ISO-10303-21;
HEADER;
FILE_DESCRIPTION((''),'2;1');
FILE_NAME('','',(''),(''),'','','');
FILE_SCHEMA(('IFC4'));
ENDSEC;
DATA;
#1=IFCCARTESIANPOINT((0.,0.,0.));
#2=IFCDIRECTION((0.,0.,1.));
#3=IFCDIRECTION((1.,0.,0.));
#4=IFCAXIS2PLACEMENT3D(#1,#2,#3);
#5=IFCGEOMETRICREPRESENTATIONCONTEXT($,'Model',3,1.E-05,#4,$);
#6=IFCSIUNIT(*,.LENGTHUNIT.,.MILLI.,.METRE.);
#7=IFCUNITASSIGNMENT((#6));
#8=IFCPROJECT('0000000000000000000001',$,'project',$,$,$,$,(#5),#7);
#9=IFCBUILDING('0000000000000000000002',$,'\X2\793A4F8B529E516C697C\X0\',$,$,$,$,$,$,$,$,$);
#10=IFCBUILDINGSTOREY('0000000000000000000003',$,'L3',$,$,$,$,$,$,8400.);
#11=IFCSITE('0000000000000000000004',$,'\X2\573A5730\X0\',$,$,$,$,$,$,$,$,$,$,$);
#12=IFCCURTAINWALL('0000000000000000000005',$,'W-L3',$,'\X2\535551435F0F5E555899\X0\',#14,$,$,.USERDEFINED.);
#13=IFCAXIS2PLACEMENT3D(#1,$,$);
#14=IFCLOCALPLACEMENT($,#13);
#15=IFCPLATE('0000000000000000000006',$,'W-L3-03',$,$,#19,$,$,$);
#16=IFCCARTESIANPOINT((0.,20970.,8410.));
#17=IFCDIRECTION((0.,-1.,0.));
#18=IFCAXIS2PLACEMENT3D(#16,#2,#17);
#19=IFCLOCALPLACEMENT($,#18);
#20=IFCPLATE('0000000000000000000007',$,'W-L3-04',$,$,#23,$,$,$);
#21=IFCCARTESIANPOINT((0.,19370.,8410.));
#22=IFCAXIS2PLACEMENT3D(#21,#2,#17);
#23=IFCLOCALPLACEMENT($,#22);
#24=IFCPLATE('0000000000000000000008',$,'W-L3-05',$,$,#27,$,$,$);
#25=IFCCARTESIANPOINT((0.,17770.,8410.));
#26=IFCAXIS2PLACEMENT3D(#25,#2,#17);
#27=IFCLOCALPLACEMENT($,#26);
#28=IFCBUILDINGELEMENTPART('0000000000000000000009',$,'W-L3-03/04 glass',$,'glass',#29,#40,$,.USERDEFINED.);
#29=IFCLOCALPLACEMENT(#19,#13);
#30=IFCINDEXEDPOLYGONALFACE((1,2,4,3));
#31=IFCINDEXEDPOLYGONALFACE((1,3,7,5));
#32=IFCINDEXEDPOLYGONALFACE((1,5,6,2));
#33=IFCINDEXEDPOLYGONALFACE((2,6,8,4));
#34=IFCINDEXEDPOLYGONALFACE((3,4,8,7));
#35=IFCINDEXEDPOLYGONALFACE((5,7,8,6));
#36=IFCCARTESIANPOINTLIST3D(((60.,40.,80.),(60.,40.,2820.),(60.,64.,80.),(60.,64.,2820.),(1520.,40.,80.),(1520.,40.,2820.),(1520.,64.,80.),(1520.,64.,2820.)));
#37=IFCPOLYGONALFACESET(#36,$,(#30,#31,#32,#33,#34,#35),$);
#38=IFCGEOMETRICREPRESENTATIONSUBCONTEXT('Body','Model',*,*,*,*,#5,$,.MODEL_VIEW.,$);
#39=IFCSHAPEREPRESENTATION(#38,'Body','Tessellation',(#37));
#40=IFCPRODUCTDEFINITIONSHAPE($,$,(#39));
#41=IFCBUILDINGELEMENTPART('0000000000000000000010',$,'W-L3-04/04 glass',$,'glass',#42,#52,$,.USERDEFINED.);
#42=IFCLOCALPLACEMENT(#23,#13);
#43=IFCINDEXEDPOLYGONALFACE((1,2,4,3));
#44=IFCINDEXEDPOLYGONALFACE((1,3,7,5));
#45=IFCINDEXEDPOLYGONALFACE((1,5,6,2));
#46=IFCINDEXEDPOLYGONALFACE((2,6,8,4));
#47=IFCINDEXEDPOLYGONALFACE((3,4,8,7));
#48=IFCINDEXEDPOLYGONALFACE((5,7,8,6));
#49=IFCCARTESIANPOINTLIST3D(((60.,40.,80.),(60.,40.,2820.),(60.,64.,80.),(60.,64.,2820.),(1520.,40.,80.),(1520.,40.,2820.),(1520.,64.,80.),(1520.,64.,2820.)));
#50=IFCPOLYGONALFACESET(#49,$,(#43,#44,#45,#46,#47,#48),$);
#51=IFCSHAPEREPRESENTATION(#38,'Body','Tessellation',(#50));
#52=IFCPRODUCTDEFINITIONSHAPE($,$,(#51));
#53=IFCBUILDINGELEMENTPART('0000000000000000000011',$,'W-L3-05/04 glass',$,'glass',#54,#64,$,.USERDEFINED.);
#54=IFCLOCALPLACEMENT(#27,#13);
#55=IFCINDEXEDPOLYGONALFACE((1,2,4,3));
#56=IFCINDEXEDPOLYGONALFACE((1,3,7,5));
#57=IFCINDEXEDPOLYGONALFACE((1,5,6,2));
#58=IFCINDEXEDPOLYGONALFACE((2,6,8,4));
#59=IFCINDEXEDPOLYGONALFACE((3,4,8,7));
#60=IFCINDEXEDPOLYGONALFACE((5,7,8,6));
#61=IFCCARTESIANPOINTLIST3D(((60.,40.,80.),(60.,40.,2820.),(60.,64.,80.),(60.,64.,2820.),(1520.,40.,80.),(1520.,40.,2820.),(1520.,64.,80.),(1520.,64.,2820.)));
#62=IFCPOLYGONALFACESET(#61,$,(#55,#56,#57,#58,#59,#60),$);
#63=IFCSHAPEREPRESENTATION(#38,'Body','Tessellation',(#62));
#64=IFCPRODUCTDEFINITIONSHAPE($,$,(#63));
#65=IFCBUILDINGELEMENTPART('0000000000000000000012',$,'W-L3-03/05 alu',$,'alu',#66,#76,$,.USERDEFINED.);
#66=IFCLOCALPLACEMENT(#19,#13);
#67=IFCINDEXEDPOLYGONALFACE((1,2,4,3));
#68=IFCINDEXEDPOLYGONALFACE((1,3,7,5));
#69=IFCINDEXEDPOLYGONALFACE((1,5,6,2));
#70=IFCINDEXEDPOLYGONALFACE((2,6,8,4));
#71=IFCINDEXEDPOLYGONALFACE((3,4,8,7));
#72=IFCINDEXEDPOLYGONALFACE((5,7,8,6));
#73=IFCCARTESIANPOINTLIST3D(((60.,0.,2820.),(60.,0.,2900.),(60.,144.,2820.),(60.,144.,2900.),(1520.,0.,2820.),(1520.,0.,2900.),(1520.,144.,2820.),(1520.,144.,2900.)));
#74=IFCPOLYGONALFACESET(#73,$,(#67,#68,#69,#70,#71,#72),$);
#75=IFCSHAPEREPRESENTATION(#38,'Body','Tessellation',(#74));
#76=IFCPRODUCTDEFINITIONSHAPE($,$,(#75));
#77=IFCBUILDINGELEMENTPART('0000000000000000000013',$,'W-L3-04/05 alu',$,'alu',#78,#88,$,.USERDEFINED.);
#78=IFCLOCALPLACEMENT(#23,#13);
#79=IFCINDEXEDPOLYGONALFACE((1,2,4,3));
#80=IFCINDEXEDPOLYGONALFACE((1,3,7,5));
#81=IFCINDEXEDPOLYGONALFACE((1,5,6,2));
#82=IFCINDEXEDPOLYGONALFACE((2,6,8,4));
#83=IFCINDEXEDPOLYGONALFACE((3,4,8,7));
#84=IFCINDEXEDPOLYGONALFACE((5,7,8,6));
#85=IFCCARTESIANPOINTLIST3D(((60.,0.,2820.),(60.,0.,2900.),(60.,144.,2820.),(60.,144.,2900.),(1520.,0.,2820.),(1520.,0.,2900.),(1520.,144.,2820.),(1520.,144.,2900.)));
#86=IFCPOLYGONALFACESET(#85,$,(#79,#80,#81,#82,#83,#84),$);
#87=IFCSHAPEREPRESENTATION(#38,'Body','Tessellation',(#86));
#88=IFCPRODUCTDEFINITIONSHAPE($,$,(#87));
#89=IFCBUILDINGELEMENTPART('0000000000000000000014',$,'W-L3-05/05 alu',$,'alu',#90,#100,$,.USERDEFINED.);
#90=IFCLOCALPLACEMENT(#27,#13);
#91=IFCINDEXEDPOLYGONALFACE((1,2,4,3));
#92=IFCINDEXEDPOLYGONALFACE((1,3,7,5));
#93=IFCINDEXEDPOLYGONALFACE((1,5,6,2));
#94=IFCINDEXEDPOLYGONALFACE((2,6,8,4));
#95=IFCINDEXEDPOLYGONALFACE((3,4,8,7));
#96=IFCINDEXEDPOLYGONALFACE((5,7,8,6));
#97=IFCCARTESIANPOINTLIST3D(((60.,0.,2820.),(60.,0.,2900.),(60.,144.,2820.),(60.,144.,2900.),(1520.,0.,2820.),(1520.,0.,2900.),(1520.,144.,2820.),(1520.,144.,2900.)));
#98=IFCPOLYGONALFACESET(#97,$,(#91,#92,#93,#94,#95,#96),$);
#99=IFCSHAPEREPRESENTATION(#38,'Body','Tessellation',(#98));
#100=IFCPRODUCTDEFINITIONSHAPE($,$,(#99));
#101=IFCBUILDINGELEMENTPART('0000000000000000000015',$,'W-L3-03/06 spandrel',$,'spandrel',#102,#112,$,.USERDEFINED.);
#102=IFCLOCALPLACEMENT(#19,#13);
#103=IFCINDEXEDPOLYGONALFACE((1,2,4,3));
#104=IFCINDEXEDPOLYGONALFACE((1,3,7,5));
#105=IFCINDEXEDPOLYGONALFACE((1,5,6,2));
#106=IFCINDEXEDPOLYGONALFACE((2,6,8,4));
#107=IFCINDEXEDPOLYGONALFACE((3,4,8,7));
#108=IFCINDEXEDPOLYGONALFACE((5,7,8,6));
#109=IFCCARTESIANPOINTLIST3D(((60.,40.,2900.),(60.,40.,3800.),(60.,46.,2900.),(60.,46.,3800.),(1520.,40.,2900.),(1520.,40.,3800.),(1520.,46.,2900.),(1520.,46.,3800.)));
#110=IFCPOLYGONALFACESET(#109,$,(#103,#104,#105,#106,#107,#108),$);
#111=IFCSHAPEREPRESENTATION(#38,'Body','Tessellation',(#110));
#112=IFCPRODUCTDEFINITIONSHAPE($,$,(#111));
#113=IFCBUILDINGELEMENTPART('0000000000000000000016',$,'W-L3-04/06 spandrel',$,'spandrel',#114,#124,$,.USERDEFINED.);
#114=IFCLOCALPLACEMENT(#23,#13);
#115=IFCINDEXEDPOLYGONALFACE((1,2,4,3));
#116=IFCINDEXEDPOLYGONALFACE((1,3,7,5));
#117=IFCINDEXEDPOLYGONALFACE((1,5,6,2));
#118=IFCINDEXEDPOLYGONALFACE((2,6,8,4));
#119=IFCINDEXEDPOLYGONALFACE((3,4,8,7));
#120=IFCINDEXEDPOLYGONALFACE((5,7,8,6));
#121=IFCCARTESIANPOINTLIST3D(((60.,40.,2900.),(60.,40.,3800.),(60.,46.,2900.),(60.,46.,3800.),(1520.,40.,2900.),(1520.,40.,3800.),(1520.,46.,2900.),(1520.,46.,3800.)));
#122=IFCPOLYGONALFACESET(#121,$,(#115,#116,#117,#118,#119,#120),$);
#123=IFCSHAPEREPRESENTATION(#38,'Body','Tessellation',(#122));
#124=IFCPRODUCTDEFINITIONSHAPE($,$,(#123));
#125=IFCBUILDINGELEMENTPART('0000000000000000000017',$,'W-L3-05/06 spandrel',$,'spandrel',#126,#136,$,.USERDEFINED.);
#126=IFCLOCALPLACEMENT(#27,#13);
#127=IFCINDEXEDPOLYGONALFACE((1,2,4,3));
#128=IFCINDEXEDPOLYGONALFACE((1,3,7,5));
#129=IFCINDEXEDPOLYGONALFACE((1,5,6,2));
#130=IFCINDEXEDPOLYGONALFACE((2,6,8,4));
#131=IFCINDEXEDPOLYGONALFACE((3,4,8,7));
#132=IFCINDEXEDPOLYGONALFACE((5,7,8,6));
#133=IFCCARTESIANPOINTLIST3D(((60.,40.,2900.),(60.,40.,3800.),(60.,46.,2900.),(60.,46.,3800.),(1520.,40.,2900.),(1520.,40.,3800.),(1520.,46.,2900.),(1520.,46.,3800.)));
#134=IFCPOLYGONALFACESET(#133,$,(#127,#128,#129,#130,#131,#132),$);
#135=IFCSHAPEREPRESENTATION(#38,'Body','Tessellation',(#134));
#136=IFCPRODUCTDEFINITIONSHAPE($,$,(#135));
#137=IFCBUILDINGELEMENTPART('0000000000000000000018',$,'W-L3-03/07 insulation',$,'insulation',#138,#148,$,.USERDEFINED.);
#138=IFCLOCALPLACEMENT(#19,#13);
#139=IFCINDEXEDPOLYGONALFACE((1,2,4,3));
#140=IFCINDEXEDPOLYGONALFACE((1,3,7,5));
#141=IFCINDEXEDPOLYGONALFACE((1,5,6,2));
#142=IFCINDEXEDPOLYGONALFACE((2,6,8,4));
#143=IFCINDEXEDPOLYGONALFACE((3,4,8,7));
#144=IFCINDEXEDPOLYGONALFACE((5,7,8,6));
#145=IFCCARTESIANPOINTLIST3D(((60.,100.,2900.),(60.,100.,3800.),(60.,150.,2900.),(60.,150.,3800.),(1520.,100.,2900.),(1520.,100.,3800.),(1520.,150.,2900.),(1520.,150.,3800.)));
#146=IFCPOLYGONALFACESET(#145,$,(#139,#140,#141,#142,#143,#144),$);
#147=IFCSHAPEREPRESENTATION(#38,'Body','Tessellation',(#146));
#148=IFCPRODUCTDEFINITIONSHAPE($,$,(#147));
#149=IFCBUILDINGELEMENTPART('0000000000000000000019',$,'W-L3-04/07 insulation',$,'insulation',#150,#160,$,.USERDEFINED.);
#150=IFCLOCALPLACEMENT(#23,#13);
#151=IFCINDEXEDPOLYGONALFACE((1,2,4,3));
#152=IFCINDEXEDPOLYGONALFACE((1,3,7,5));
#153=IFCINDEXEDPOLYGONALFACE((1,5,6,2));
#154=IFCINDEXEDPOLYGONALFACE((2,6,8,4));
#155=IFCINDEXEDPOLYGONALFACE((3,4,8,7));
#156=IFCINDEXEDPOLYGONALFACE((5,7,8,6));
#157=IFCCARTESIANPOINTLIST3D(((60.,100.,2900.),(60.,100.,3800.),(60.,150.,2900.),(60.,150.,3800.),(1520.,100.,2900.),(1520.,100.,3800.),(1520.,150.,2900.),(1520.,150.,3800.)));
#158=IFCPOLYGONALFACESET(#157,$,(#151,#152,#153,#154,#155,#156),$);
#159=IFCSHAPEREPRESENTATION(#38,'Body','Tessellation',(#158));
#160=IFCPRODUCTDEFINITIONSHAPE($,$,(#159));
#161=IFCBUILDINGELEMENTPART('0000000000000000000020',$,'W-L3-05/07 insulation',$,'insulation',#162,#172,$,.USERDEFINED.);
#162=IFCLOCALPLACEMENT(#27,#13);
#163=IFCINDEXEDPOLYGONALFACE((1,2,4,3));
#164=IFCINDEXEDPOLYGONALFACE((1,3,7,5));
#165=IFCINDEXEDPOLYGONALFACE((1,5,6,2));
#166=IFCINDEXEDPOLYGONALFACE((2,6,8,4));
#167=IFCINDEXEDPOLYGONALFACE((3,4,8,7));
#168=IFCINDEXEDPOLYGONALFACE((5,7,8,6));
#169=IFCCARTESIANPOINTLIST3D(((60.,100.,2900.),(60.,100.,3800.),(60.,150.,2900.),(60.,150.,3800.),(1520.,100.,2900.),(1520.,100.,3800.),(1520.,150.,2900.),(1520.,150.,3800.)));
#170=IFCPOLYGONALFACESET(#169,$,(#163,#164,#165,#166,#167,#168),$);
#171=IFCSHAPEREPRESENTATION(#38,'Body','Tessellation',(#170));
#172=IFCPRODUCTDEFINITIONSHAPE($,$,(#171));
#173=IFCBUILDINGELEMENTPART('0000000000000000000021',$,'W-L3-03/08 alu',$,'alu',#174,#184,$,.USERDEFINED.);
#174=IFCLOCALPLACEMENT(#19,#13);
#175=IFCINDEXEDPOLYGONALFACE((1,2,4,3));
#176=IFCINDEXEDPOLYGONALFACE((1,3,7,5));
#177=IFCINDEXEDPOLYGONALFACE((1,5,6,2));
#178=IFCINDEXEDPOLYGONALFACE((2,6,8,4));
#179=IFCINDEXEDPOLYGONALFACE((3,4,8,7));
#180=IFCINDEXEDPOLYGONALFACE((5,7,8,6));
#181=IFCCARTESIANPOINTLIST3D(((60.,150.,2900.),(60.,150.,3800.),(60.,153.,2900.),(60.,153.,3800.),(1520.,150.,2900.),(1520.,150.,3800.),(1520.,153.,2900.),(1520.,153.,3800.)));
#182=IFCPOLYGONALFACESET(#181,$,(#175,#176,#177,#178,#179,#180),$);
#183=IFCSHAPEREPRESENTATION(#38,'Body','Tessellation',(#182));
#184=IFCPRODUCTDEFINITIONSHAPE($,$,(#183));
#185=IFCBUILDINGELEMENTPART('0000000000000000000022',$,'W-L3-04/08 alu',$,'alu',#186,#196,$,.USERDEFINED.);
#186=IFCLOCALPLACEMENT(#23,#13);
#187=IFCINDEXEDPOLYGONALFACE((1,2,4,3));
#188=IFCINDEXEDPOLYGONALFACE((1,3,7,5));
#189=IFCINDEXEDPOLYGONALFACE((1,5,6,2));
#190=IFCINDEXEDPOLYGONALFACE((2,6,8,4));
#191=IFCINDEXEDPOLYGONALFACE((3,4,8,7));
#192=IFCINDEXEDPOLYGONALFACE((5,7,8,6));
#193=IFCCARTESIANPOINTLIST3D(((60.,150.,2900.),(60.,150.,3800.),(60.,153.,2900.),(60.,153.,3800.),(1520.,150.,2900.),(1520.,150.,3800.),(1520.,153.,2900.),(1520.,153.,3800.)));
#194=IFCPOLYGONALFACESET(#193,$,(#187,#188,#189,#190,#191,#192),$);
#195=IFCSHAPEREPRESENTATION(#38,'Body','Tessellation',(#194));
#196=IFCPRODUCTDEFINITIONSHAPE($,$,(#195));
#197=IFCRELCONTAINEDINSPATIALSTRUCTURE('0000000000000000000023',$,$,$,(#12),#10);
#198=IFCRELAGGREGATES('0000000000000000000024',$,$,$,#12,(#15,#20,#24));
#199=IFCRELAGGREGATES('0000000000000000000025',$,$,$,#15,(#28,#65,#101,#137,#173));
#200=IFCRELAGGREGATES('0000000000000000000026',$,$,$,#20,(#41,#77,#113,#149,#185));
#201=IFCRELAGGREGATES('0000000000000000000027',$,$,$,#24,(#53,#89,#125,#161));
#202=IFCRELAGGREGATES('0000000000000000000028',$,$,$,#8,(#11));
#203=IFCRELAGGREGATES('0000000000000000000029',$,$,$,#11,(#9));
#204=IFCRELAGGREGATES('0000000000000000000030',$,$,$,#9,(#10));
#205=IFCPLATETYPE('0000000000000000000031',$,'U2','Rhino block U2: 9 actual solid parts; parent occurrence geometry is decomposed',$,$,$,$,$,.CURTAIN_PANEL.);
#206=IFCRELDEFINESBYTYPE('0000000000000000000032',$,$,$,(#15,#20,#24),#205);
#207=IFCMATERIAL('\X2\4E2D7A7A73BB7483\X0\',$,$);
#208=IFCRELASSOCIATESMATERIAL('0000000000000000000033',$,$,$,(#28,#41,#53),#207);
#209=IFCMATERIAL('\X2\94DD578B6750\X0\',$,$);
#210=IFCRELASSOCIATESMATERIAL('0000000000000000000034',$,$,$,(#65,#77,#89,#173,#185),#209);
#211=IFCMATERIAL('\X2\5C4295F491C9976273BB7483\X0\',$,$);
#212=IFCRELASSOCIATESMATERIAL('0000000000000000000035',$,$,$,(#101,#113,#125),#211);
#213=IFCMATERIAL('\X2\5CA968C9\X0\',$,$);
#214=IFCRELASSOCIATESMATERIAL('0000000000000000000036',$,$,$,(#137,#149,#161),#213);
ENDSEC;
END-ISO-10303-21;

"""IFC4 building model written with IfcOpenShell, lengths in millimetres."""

from ifc_helpers import new_model, si_unit, frame, frame_2d, origin, origin_with_axes, place, context, subcontext, project, spatial, rectangle, extrude, source, transform, mapped, material, type_object, element, aggregate, save


model = new_model("IFC4")

# Units and contexts
model_context = context("Model", 3, precision=1e-05, world=origin_with_axes())
body_context = subcontext(model_context, "Body", "Model", "MODEL_VIEW")
ifc_project = project(units=[si_unit("LENGTHUNIT", "METRE", prefix="MILLI")], contexts=[model_context])

# Site, building, storey
site = spatial("IfcSite", under=ifc_project, Name="场地")
building = spatial("IfcBuilding", under=site, Name="示例办公楼")
storey = spatial("IfcBuildingStorey", under=building, Name="L3", Elevation=8400.0)

# Curtain wall, plates, building element parts
curtain_wall = element("IfcCurtainWall", 1, inside=storey, Name="W-L3", ObjectType="单元式幕墙", PredefinedType="USERDEFINED")
plate_type = type_object("IfcPlateType", Name="U2", Description="Rhino block U2: 9 actual solid parts; parent occurrence geometry is decomposed", PredefinedType="CURTAIN_PANEL")
plate_1_placement = place(None, frame((0.0, 20970.0, 8410.0), z_axis=(0.0, 0.0, 1.0), x_axis=(0.0, -1.0, 0.0)))
plate_1 = element("IfcPlate", 2, at=plate_1_placement, type_object=plate_type, Name="W-L3-03")
ifc_material_1 = material(Name="铝型材")
plate_2_placement = place(None, frame((0.0, 19370.0, 8410.0), z_axis=(0.0, 0.0, 1.0), x_axis=(0.0, -1.0, 0.0)))
plate_2 = element("IfcPlate", 3, at=plate_2_placement, type_object=plate_type, Name="W-L3-04")
plate_3_placement = place(None, frame((0.0, 17770.0, 8410.0), z_axis=(0.0, 0.0, 1.0), x_axis=(0.0, -1.0, 0.0)))
plate_3 = element("IfcPlate", 4, at=plate_3_placement, type_object=plate_type, Name="W-L3-05")
aggregate(curtain_wall, [plate_1, plate_2, plate_3])
ifc_material_2 = material(Name="中空玻璃")
shared_shape_1 = source(origin(), body_context, "Body", "SweptSolid", [
    extrude(rectangle(XDim=1460.0, YDim=24.0, at=frame_2d((790.0, 52.0))), frame((0.0, 0.0, 80.0)), (0.0, 0.0, 1.0), 2740.0),
])
building_element_part_1_placement = place(plate_1_placement, origin())
building_element_part_1 = element("IfcBuildingElementPart", 5, at=building_element_part_1_placement, material=ifc_material_2, Name="W-L3-03/04 glass", ObjectType="glass", PredefinedType="USERDEFINED", context=body_context, shape_type="MappedRepresentation", body=[
    mapped(shared_shape_1, transform((0.0, 0.0, 0.0))),
])
building_element_part_2_placement = place(plate_2_placement, origin())
building_element_part_2 = element("IfcBuildingElementPart", 6, at=building_element_part_2_placement, material=ifc_material_2, Name="W-L3-04/04 glass", ObjectType="glass", PredefinedType="USERDEFINED", context=body_context, shape_type="MappedRepresentation", body=[
    mapped(shared_shape_1, transform((0.0, 0.0, 0.0))),
])
building_element_part_3_placement = place(plate_3_placement, origin())
building_element_part_3 = element("IfcBuildingElementPart", 7, at=building_element_part_3_placement, material=ifc_material_2, Name="W-L3-05/04 glass", ObjectType="glass", PredefinedType="USERDEFINED", context=body_context, shape_type="MappedRepresentation", body=[
    mapped(shared_shape_1, transform((0.0, 0.0, 0.0))),
])
shared_shape_2 = source(origin(), body_context, "Body", "SweptSolid", [
    extrude(rectangle(XDim=1460.0, YDim=144.0, at=frame_2d((790.0, 72.0))), frame((0.0, 0.0, 2820.0)), (0.0, 0.0, 1.0), 80.0),
])
building_element_part_4_placement = place(plate_1_placement, origin())
building_element_part_4 = element("IfcBuildingElementPart", 8, at=building_element_part_4_placement, material=ifc_material_1, Name="W-L3-03/05 alu", ObjectType="alu", PredefinedType="USERDEFINED", context=body_context, shape_type="MappedRepresentation", body=[
    mapped(shared_shape_2, transform((0.0, 0.0, 0.0))),
])
building_element_part_5_placement = place(plate_2_placement, origin())
building_element_part_5 = element("IfcBuildingElementPart", 9, at=building_element_part_5_placement, material=ifc_material_1, Name="W-L3-04/05 alu", ObjectType="alu", PredefinedType="USERDEFINED", context=body_context, shape_type="MappedRepresentation", body=[
    mapped(shared_shape_2, transform((0.0, 0.0, 0.0))),
])
building_element_part_6_placement = place(plate_3_placement, origin())
building_element_part_6 = element("IfcBuildingElementPart", 10, at=building_element_part_6_placement, material=ifc_material_1, Name="W-L3-05/05 alu", ObjectType="alu", PredefinedType="USERDEFINED", context=body_context, shape_type="MappedRepresentation", body=[
    mapped(shared_shape_2, transform((0.0, 0.0, 0.0))),
])
ifc_material_3 = material(Name="层间釉面玻璃")
shared_shape_3 = source(origin(), body_context, "Body", "SweptSolid", [
    extrude(rectangle(XDim=1460.0, YDim=6.0, at=frame_2d((790.0, 43.0))), frame((0.0, 0.0, 2900.0)), (0.0, 0.0, 1.0), 900.0),
])
building_element_part_7_placement = place(plate_1_placement, origin())
building_element_part_7 = element("IfcBuildingElementPart", 11, at=building_element_part_7_placement, material=ifc_material_3, Name="W-L3-03/06 spandrel", ObjectType="spandrel", PredefinedType="USERDEFINED", context=body_context, shape_type="MappedRepresentation", body=[
    mapped(shared_shape_3, transform((0.0, 0.0, 0.0))),
])
building_element_part_8_placement = place(plate_2_placement, origin())
building_element_part_8 = element("IfcBuildingElementPart", 12, at=building_element_part_8_placement, material=ifc_material_3, Name="W-L3-04/06 spandrel", ObjectType="spandrel", PredefinedType="USERDEFINED", context=body_context, shape_type="MappedRepresentation", body=[
    mapped(shared_shape_3, transform((0.0, 0.0, 0.0))),
])
building_element_part_9_placement = place(plate_3_placement, origin())
building_element_part_9 = element("IfcBuildingElementPart", 13, at=building_element_part_9_placement, material=ifc_material_3, Name="W-L3-05/06 spandrel", ObjectType="spandrel", PredefinedType="USERDEFINED", context=body_context, shape_type="MappedRepresentation", body=[
    mapped(shared_shape_3, transform((0.0, 0.0, 0.0))),
])
ifc_material_4 = material(Name="岩棉")
shared_shape_4 = source(origin(), body_context, "Body", "SweptSolid", [
    extrude(rectangle(XDim=1460.0, YDim=50.0, at=frame_2d((790.0, 125.0))), frame((0.0, 0.0, 2900.0)), (0.0, 0.0, 1.0), 900.0),
])
building_element_part_10_placement = place(plate_1_placement, origin())
building_element_part_10 = element("IfcBuildingElementPart", 14, at=building_element_part_10_placement, material=ifc_material_4, Name="W-L3-03/07 insulation", ObjectType="insulation", PredefinedType="USERDEFINED", context=body_context, shape_type="MappedRepresentation", body=[
    mapped(shared_shape_4, transform((0.0, 0.0, 0.0))),
])
building_element_part_11_placement = place(plate_2_placement, origin())
building_element_part_11 = element("IfcBuildingElementPart", 15, at=building_element_part_11_placement, material=ifc_material_4, Name="W-L3-04/07 insulation", ObjectType="insulation", PredefinedType="USERDEFINED", context=body_context, shape_type="MappedRepresentation", body=[
    mapped(shared_shape_4, transform((0.0, 0.0, 0.0))),
])
building_element_part_12_placement = place(plate_3_placement, origin())
building_element_part_12 = element("IfcBuildingElementPart", 16, at=building_element_part_12_placement, material=ifc_material_4, Name="W-L3-05/07 insulation", ObjectType="insulation", PredefinedType="USERDEFINED", context=body_context, shape_type="MappedRepresentation", body=[
    mapped(shared_shape_4, transform((0.0, 0.0, 0.0))),
])
shared_shape_5 = source(origin(), body_context, "Body", "SweptSolid", [
    extrude(rectangle(XDim=1460.0, YDim=3.0, at=frame_2d((790.0, 151.5))), frame((0.0, 0.0, 2900.0)), (0.0, 0.0, 1.0), 900.0),
])
building_element_part_13_placement = place(plate_1_placement, origin())
building_element_part_13 = element("IfcBuildingElementPart", 17, at=building_element_part_13_placement, material=ifc_material_1, Name="W-L3-03/08 alu", ObjectType="alu", PredefinedType="USERDEFINED", context=body_context, shape_type="MappedRepresentation", body=[
    mapped(shared_shape_5, transform((0.0, 0.0, 0.0))),
])
aggregate(plate_1, [building_element_part_1, building_element_part_4, building_element_part_7, building_element_part_10, building_element_part_13])
building_element_part_14_placement = place(plate_2_placement, origin())
building_element_part_14 = element("IfcBuildingElementPart", 18, at=building_element_part_14_placement, material=ifc_material_1, Name="W-L3-04/08 alu", ObjectType="alu", PredefinedType="USERDEFINED", context=body_context, shape_type="MappedRepresentation", body=[
    mapped(shared_shape_5, transform((0.0, 0.0, 0.0))),
])
aggregate(plate_2, [building_element_part_2, building_element_part_5, building_element_part_8, building_element_part_11, building_element_part_14])
aggregate(plate_3, [building_element_part_3, building_element_part_6, building_element_part_9, building_element_part_12])

save(model, "model.ifc")
